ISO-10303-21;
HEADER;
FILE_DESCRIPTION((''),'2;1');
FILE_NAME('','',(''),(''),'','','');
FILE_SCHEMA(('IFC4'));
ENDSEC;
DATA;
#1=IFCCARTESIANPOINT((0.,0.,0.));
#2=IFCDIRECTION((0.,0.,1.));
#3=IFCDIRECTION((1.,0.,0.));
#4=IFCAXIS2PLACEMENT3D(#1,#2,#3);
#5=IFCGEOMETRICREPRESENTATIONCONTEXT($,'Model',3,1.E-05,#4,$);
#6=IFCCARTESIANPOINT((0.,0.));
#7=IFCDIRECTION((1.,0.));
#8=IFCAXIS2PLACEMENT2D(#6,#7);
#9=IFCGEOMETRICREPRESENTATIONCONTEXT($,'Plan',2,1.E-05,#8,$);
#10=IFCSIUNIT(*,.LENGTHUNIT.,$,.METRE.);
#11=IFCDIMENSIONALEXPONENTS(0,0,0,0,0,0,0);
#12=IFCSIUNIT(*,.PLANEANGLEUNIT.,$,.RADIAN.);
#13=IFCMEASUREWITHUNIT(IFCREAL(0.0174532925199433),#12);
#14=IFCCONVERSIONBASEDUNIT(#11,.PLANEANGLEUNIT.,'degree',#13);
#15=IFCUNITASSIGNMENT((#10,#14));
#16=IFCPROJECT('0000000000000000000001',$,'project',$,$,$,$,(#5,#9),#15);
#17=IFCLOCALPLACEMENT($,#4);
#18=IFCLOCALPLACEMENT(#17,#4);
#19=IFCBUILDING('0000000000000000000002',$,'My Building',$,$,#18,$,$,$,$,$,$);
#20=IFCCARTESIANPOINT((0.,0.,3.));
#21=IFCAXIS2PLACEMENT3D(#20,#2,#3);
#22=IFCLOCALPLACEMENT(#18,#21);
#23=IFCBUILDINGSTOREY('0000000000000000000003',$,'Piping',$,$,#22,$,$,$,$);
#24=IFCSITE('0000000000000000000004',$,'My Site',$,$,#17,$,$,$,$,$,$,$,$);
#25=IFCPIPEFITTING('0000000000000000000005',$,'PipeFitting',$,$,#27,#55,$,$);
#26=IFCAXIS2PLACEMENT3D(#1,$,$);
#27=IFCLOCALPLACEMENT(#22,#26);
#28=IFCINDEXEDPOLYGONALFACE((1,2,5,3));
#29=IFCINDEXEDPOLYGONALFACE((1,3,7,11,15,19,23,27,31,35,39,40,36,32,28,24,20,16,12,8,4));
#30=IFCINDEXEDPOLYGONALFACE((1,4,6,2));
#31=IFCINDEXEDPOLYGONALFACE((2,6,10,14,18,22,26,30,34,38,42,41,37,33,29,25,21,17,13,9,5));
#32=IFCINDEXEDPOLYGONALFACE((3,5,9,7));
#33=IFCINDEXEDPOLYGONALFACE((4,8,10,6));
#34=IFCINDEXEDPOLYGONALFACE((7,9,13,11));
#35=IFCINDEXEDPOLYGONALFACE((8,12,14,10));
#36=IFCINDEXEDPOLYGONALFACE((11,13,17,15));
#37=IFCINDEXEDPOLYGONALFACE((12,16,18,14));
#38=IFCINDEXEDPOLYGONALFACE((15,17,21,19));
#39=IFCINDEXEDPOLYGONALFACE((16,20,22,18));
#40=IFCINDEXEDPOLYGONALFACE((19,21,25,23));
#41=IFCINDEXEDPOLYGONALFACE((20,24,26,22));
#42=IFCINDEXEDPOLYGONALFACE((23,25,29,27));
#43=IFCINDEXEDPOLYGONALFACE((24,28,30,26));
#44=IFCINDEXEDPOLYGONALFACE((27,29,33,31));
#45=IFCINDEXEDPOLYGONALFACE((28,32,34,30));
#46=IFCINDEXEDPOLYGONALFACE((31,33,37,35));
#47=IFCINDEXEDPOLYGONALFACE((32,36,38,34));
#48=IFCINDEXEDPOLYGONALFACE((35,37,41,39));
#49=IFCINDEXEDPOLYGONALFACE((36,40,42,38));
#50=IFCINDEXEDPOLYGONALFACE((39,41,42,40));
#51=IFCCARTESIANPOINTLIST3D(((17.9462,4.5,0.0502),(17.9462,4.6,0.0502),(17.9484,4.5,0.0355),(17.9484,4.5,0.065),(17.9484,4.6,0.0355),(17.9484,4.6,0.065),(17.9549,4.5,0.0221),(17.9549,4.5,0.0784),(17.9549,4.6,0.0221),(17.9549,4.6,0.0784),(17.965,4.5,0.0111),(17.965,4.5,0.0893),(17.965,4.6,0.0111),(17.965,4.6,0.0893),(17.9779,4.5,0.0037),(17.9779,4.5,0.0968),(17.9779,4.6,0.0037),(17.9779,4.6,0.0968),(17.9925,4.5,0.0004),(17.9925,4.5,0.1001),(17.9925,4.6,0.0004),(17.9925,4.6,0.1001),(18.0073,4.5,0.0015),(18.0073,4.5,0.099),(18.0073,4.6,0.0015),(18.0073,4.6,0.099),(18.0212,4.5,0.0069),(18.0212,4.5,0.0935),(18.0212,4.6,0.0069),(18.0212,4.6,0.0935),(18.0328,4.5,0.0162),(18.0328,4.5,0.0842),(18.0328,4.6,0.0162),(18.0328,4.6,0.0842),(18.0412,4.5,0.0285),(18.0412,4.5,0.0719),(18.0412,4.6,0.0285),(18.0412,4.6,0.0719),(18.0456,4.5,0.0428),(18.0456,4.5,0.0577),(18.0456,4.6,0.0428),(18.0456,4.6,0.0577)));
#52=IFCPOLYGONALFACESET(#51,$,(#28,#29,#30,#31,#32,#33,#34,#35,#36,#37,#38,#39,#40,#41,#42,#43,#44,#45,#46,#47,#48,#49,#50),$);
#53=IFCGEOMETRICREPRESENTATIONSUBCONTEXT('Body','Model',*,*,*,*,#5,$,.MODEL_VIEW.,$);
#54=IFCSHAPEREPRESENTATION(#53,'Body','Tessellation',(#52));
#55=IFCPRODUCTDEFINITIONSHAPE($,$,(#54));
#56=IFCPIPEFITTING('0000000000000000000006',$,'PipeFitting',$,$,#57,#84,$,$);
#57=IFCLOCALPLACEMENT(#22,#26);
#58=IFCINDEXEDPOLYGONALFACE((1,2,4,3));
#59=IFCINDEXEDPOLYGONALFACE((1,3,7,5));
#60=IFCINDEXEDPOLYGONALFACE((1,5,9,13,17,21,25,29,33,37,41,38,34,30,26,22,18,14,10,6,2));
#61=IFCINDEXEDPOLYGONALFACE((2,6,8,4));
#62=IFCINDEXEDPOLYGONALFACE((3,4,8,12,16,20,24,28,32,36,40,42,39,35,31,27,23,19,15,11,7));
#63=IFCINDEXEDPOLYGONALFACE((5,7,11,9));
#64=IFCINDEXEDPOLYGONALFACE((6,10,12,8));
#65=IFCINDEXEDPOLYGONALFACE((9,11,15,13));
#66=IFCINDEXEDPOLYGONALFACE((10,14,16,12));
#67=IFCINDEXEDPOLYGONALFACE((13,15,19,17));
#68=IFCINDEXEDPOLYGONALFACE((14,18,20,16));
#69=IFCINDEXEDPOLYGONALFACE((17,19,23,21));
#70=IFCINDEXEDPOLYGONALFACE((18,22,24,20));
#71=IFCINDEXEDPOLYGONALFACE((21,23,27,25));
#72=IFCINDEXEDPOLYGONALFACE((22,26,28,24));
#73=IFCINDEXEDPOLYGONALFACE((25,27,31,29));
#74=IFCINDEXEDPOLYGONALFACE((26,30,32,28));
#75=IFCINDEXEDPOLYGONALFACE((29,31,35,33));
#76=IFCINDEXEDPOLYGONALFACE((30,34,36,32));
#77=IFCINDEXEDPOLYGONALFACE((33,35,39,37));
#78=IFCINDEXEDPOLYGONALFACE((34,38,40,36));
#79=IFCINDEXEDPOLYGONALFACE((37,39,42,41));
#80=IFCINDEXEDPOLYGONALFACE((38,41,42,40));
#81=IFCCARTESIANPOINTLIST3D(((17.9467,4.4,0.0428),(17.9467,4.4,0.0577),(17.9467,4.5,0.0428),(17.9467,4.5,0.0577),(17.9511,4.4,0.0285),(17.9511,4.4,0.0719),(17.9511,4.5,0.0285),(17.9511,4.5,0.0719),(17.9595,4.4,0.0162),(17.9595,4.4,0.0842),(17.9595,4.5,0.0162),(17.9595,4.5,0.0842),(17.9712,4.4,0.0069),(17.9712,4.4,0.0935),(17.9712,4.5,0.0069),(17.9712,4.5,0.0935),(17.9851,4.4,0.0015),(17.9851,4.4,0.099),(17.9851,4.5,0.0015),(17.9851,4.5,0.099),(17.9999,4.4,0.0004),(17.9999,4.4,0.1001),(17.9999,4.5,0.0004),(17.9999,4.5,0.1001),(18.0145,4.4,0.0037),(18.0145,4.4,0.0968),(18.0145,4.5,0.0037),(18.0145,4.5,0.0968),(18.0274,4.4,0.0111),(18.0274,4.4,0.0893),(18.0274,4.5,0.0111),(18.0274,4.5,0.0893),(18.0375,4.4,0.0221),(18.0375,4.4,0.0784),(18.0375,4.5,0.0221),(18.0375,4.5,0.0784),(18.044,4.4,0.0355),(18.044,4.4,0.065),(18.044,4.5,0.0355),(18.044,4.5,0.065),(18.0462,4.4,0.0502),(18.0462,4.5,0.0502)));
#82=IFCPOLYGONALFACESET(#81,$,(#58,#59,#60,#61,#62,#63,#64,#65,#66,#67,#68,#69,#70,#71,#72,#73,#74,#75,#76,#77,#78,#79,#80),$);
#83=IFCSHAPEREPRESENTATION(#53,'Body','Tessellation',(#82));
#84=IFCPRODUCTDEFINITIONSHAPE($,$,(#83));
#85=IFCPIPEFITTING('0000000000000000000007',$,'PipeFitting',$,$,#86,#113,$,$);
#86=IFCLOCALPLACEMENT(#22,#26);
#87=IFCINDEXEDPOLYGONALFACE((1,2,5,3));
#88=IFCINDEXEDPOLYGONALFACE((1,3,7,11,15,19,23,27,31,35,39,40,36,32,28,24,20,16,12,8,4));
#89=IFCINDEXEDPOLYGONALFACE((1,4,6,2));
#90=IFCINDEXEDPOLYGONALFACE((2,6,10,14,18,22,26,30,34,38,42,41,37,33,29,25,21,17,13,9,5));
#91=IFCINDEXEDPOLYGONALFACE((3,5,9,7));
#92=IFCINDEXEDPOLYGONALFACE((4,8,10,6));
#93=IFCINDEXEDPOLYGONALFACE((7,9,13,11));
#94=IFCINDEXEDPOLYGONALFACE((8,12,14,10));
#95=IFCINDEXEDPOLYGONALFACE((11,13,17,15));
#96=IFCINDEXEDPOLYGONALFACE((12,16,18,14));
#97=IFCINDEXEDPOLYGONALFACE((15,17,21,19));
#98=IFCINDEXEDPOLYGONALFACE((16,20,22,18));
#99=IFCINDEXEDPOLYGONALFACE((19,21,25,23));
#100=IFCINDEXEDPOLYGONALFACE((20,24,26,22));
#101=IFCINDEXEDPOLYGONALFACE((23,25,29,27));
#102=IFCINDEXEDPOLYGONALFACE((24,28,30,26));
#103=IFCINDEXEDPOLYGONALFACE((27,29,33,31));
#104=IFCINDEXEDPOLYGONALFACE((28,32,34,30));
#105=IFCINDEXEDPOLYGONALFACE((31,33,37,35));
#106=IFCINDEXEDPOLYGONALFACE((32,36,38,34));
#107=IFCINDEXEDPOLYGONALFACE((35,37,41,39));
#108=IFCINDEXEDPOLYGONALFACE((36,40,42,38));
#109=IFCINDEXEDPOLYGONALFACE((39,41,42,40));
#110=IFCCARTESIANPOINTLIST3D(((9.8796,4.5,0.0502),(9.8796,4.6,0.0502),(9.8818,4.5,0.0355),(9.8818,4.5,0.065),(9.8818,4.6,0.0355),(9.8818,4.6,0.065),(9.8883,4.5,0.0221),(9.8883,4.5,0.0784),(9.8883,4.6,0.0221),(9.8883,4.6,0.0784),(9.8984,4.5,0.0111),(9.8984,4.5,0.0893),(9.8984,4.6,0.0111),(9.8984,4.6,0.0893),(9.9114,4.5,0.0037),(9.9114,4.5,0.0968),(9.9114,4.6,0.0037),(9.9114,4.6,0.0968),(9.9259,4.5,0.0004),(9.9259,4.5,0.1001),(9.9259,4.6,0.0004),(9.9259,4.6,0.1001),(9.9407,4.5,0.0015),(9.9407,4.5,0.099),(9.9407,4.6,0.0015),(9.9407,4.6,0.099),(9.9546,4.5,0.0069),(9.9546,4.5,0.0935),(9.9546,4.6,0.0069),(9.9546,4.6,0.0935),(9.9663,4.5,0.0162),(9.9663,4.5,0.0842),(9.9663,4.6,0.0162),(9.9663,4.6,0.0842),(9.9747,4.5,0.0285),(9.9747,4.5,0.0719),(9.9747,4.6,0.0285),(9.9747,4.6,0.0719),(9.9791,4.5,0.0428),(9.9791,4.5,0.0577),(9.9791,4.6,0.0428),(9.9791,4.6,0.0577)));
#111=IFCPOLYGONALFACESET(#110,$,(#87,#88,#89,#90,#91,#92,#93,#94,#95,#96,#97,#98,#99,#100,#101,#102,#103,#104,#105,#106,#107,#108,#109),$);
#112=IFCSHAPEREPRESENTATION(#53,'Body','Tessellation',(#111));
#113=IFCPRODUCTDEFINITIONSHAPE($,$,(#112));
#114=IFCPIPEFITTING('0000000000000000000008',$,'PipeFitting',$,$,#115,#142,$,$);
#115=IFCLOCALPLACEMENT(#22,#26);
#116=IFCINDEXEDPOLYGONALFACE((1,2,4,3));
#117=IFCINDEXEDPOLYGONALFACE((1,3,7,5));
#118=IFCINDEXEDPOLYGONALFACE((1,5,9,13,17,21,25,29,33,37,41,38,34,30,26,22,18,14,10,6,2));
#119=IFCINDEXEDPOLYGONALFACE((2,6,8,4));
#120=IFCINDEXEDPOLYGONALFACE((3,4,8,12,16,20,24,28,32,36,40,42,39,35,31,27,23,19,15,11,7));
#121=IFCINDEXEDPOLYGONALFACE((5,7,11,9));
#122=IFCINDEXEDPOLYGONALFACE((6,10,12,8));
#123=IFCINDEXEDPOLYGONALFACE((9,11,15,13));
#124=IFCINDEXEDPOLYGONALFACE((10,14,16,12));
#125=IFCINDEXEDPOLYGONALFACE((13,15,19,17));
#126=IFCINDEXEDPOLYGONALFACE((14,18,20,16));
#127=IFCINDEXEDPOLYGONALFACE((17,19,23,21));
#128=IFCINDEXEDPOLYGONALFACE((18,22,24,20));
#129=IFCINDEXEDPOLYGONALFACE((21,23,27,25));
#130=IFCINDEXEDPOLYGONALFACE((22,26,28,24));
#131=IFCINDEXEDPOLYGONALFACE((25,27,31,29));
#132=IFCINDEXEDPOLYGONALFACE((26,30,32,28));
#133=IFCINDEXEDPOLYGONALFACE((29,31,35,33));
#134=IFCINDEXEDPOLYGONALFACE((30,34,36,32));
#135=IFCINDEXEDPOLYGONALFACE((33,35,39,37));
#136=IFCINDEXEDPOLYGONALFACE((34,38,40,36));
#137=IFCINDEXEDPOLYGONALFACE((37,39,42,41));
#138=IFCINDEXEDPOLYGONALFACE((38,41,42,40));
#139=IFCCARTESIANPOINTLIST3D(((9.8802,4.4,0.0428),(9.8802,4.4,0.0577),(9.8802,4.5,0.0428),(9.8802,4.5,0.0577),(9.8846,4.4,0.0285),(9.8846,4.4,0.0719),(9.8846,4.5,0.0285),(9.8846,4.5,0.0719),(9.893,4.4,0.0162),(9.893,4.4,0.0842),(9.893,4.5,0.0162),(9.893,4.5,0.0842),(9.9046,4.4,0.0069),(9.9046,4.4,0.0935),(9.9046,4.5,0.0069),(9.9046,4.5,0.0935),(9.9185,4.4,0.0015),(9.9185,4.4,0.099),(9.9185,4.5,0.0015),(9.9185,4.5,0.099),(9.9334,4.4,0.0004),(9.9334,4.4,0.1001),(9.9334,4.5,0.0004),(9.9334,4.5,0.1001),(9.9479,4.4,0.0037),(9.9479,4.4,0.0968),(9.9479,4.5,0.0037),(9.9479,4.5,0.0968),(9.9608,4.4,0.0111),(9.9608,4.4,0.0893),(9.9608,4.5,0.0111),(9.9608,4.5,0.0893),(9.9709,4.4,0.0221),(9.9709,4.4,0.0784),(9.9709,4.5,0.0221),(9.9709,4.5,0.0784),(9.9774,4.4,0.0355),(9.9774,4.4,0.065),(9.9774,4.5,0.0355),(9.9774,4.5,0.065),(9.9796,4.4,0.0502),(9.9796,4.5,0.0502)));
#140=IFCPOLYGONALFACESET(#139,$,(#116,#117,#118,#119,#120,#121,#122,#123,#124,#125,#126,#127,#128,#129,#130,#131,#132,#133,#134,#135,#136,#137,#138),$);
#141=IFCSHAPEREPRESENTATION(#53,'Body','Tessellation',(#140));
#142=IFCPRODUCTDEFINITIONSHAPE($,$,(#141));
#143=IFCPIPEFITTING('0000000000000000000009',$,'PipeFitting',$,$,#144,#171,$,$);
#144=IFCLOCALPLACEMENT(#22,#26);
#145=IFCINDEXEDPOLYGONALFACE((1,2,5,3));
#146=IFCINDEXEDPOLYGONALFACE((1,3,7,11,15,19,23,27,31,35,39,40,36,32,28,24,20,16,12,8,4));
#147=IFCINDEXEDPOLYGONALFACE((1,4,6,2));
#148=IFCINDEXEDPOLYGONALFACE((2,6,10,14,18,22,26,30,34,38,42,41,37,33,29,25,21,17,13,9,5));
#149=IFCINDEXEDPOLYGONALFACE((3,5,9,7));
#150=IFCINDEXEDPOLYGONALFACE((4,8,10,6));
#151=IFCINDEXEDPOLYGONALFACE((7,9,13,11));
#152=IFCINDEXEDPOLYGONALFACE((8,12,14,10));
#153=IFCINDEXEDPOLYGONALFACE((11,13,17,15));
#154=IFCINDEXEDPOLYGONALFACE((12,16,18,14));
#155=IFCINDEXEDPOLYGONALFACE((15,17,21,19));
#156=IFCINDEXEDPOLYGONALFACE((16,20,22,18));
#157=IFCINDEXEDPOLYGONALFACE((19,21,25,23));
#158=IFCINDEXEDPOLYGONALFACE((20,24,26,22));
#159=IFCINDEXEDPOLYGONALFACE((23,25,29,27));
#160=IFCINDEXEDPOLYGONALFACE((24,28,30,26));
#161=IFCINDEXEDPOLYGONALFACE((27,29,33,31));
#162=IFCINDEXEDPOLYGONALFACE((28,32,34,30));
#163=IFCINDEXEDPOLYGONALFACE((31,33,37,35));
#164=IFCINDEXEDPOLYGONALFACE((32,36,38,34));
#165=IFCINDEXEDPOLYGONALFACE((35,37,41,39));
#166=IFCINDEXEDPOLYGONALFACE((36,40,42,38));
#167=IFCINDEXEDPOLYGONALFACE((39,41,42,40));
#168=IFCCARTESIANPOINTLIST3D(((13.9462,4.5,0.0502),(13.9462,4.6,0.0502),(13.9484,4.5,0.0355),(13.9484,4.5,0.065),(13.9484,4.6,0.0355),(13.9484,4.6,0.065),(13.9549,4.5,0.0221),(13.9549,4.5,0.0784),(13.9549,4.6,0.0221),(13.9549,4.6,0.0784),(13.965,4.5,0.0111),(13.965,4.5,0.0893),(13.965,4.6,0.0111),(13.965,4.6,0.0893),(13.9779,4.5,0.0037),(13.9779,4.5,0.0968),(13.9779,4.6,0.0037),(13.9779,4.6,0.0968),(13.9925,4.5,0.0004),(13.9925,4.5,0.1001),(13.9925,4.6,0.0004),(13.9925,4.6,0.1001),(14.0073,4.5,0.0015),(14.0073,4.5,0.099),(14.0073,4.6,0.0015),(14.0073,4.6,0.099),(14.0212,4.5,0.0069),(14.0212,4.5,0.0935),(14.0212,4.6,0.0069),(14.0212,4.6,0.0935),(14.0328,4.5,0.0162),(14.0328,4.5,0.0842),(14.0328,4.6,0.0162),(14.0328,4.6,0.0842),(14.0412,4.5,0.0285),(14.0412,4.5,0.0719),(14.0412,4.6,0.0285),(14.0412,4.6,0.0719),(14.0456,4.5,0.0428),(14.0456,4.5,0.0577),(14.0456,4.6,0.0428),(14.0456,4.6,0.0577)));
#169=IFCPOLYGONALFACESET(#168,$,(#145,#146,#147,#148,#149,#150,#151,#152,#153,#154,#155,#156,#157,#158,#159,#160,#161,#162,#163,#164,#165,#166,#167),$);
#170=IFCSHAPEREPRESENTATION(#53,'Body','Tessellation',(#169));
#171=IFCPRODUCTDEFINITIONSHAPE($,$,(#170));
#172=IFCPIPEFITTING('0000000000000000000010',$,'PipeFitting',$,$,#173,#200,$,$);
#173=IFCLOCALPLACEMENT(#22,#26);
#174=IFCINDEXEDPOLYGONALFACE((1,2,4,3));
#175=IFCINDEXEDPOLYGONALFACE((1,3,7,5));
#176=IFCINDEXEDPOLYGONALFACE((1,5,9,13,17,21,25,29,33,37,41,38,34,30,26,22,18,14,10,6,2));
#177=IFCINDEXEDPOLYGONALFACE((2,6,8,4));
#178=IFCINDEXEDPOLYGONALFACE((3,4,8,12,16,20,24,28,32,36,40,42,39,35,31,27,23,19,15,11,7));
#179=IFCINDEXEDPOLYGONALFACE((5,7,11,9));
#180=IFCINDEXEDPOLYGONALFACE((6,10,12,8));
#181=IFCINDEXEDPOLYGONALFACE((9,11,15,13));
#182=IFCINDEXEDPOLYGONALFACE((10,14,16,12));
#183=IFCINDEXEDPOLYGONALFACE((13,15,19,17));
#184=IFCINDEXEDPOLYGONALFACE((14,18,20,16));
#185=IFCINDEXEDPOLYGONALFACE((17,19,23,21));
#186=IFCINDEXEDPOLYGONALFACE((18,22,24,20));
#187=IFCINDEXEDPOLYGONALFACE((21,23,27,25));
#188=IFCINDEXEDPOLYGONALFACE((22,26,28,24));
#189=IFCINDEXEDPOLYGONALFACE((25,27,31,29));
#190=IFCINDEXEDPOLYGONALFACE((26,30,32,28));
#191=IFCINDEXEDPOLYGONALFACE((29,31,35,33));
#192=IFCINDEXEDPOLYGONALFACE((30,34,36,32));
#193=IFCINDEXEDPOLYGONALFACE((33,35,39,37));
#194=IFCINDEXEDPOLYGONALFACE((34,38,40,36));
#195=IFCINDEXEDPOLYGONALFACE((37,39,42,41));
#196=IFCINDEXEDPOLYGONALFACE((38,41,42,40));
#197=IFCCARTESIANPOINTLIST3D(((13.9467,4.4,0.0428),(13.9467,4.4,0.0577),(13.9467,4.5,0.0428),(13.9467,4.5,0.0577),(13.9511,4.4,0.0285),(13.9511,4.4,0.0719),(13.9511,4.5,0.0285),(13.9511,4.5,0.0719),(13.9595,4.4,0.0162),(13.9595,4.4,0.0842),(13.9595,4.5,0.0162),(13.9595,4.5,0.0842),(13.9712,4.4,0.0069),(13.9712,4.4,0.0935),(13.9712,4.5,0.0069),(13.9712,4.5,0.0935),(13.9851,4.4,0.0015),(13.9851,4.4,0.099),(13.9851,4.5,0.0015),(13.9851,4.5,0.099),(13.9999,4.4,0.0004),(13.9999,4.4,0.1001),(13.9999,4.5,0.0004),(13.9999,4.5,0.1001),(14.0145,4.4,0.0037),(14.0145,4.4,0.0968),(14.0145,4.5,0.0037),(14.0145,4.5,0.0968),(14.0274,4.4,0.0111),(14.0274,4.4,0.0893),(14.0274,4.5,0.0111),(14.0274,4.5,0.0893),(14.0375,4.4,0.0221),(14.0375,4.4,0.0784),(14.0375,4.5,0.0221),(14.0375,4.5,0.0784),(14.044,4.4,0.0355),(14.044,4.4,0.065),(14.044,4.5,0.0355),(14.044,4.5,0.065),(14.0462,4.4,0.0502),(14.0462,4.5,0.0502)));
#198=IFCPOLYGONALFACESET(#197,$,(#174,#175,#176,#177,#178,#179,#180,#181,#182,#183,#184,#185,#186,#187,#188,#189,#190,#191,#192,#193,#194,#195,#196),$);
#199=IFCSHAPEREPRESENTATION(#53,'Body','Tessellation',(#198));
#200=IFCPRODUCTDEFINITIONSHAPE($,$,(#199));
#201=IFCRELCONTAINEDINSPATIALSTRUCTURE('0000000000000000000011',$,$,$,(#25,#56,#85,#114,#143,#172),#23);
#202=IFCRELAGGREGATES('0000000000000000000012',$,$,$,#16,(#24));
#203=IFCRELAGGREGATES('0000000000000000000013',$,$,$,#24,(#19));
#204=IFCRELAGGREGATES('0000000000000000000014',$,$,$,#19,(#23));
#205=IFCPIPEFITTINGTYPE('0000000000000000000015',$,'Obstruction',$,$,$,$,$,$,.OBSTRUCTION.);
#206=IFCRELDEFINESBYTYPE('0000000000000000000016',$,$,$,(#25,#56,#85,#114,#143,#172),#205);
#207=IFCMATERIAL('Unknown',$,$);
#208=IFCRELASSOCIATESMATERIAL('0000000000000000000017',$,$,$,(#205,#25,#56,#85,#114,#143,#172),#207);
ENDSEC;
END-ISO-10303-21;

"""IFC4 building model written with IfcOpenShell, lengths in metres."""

from ifc_helpers import new_model, entity, si_unit, converted_unit, frame, origin_with_axes, origin_2d_with_axis, place, context, subcontext, project, spatial, circle, extrude, material, material_profile, profile_set, profile_usage, type_object, element, save


model = new_model("IFC4")

# Units and contexts
model_context = context("Model", 3, precision=1e-05, world=origin_with_axes())
plan_context = context("Plan", 2, precision=1e-05, world=origin_2d_with_axis())
body_context = subcontext(model_context, "Body", "Model", "MODEL_VIEW")
ifc_project = project(units=[si_unit("LENGTHUNIT", "METRE"), converted_unit("PLANEANGLEUNIT", "degree", entity("IfcReal", 0.0174532925199433), si_unit("PLANEANGLEUNIT", "RADIAN"), dimensions=[0, 0, 0, 0, 0, 0, 0])], contexts=[model_context, plan_context])

# Site, building, storey
site_placement = place(None, origin_with_axes())
site = spatial("IfcSite", under=ifc_project, at=site_placement, Name="My Site")
building_placement = place(site_placement, origin_with_axes())
building = spatial("IfcBuilding", under=site, at=building_placement, Name="My Building")
storey_placement = place(building_placement, frame((0.0, 0.0, 3.0), z_axis=(0.0, 0.0, 1.0), x_axis=(1.0, 0.0, 0.0)))
storey = spatial("IfcBuildingStorey", under=building, at=storey_placement, Name="Piping")

# Shared definitions
ifc_material = material(Name="Unknown")

# Pipe fittings
ifc_material_profile_1 = material_profile(ifc_material, circle(Radius=0.05))
ifc_profile_set_1 = profile_set([ifc_material_profile_1])
ifc_profile_usage_1 = profile_usage(ifc_profile_set_1, cardinal=5)
pipe_fitting_type_1 = type_object("IfcPipeFittingType", Name="Obstruction", PredefinedType="OBSTRUCTION", material=ifc_profile_set_1)
pipe_fitting_1_placement = place(storey_placement, frame((17.9962, 4.5, 0.0502), z_axis=(0.0, 1.0, 0.000006), x_axis=(-1.0, 0.0, 0.0)))
element("IfcPipeFitting", 1, at=pipe_fitting_1_placement, inside=storey, type_object=pipe_fitting_type_1, material=ifc_profile_usage_1, Name="PipeFitting", context=body_context, shape_type="SweptSolid", body=[
    extrude(circle(Radius=0.05), origin_with_axes(), (0.0, 0.0, 1.0), 0.1),
])
ifc_profile_usage_2 = profile_usage(ifc_profile_set_1, cardinal=5)
pipe_fitting_2_placement = place(storey_placement, frame((17.9962, 4.5, 0.0502), z_axis=(0.0, -1.0, 0.000006), x_axis=(1.0, 0.0, 0.0)))
element("IfcPipeFitting", 2, at=pipe_fitting_2_placement, inside=storey, type_object=pipe_fitting_type_1, material=ifc_profile_usage_2, Name="PipeFitting", context=body_context, shape_type="SweptSolid", body=[
    extrude(circle(Radius=0.05), origin_with_axes(), (0.0, 0.0, 1.0), 0.1),
])
ifc_profile_usage_3 = profile_usage(ifc_profile_set_1, cardinal=5)
pipe_fitting_3_placement = place(storey_placement, frame((9.9296, 4.5, 0.0502), z_axis=(0.0, 1.0, 0.000006), x_axis=(-1.0, 0.0, 0.0)))
element("IfcPipeFitting", 3, at=pipe_fitting_3_placement, inside=storey, type_object=pipe_fitting_type_1, material=ifc_profile_usage_3, Name="PipeFitting", context=body_context, shape_type="SweptSolid", body=[
    extrude(circle(Radius=0.05), origin_with_axes(), (0.0, 0.0, 1.0), 0.1),
])
ifc_profile_usage_4 = profile_usage(ifc_profile_set_1, cardinal=5)
pipe_fitting_4_placement = place(storey_placement, frame((9.9296, 4.5, 0.0502), z_axis=(0.0, -1.0, 0.000006), x_axis=(1.0, 0.0, 0.0)))
element("IfcPipeFitting", 4, at=pipe_fitting_4_placement, inside=storey, type_object=pipe_fitting_type_1, material=ifc_profile_usage_4, Name="PipeFitting", context=body_context, shape_type="SweptSolid", body=[
    extrude(circle(Radius=0.05), origin_with_axes(), (0.0, 0.0, 1.0), 0.1),
])
ifc_profile_usage_5 = profile_usage(ifc_profile_set_1, cardinal=5)
pipe_fitting_5_placement = place(storey_placement, frame((13.9962, 4.5, 0.0502), z_axis=(0.0, 1.0, 0.000006), x_axis=(-1.0, 0.0, 0.0)))
element("IfcPipeFitting", 5, at=pipe_fitting_5_placement, inside=storey, type_object=pipe_fitting_type_1, material=ifc_profile_usage_5, Name="PipeFitting", context=body_context, shape_type="SweptSolid", body=[
    extrude(circle(Radius=0.05), origin_with_axes(), (0.0, 0.0, 1.0), 0.1),
])
ifc_profile_usage_6 = profile_usage(ifc_profile_set_1, cardinal=5)
pipe_fitting_6_placement = place(storey_placement, frame((13.9962, 4.5, 0.0502), z_axis=(0.0, -1.0, 0.000006), x_axis=(1.0, 0.0, 0.0)))
element("IfcPipeFitting", 6, at=pipe_fitting_6_placement, inside=storey, type_object=pipe_fitting_type_1, material=ifc_profile_usage_6, Name="PipeFitting", context=body_context, shape_type="SweptSolid", body=[
    extrude(circle(Radius=0.05), origin_with_axes(), (0.0, 0.0, 1.0), 0.1),
])

save(model, "model.ifc")
